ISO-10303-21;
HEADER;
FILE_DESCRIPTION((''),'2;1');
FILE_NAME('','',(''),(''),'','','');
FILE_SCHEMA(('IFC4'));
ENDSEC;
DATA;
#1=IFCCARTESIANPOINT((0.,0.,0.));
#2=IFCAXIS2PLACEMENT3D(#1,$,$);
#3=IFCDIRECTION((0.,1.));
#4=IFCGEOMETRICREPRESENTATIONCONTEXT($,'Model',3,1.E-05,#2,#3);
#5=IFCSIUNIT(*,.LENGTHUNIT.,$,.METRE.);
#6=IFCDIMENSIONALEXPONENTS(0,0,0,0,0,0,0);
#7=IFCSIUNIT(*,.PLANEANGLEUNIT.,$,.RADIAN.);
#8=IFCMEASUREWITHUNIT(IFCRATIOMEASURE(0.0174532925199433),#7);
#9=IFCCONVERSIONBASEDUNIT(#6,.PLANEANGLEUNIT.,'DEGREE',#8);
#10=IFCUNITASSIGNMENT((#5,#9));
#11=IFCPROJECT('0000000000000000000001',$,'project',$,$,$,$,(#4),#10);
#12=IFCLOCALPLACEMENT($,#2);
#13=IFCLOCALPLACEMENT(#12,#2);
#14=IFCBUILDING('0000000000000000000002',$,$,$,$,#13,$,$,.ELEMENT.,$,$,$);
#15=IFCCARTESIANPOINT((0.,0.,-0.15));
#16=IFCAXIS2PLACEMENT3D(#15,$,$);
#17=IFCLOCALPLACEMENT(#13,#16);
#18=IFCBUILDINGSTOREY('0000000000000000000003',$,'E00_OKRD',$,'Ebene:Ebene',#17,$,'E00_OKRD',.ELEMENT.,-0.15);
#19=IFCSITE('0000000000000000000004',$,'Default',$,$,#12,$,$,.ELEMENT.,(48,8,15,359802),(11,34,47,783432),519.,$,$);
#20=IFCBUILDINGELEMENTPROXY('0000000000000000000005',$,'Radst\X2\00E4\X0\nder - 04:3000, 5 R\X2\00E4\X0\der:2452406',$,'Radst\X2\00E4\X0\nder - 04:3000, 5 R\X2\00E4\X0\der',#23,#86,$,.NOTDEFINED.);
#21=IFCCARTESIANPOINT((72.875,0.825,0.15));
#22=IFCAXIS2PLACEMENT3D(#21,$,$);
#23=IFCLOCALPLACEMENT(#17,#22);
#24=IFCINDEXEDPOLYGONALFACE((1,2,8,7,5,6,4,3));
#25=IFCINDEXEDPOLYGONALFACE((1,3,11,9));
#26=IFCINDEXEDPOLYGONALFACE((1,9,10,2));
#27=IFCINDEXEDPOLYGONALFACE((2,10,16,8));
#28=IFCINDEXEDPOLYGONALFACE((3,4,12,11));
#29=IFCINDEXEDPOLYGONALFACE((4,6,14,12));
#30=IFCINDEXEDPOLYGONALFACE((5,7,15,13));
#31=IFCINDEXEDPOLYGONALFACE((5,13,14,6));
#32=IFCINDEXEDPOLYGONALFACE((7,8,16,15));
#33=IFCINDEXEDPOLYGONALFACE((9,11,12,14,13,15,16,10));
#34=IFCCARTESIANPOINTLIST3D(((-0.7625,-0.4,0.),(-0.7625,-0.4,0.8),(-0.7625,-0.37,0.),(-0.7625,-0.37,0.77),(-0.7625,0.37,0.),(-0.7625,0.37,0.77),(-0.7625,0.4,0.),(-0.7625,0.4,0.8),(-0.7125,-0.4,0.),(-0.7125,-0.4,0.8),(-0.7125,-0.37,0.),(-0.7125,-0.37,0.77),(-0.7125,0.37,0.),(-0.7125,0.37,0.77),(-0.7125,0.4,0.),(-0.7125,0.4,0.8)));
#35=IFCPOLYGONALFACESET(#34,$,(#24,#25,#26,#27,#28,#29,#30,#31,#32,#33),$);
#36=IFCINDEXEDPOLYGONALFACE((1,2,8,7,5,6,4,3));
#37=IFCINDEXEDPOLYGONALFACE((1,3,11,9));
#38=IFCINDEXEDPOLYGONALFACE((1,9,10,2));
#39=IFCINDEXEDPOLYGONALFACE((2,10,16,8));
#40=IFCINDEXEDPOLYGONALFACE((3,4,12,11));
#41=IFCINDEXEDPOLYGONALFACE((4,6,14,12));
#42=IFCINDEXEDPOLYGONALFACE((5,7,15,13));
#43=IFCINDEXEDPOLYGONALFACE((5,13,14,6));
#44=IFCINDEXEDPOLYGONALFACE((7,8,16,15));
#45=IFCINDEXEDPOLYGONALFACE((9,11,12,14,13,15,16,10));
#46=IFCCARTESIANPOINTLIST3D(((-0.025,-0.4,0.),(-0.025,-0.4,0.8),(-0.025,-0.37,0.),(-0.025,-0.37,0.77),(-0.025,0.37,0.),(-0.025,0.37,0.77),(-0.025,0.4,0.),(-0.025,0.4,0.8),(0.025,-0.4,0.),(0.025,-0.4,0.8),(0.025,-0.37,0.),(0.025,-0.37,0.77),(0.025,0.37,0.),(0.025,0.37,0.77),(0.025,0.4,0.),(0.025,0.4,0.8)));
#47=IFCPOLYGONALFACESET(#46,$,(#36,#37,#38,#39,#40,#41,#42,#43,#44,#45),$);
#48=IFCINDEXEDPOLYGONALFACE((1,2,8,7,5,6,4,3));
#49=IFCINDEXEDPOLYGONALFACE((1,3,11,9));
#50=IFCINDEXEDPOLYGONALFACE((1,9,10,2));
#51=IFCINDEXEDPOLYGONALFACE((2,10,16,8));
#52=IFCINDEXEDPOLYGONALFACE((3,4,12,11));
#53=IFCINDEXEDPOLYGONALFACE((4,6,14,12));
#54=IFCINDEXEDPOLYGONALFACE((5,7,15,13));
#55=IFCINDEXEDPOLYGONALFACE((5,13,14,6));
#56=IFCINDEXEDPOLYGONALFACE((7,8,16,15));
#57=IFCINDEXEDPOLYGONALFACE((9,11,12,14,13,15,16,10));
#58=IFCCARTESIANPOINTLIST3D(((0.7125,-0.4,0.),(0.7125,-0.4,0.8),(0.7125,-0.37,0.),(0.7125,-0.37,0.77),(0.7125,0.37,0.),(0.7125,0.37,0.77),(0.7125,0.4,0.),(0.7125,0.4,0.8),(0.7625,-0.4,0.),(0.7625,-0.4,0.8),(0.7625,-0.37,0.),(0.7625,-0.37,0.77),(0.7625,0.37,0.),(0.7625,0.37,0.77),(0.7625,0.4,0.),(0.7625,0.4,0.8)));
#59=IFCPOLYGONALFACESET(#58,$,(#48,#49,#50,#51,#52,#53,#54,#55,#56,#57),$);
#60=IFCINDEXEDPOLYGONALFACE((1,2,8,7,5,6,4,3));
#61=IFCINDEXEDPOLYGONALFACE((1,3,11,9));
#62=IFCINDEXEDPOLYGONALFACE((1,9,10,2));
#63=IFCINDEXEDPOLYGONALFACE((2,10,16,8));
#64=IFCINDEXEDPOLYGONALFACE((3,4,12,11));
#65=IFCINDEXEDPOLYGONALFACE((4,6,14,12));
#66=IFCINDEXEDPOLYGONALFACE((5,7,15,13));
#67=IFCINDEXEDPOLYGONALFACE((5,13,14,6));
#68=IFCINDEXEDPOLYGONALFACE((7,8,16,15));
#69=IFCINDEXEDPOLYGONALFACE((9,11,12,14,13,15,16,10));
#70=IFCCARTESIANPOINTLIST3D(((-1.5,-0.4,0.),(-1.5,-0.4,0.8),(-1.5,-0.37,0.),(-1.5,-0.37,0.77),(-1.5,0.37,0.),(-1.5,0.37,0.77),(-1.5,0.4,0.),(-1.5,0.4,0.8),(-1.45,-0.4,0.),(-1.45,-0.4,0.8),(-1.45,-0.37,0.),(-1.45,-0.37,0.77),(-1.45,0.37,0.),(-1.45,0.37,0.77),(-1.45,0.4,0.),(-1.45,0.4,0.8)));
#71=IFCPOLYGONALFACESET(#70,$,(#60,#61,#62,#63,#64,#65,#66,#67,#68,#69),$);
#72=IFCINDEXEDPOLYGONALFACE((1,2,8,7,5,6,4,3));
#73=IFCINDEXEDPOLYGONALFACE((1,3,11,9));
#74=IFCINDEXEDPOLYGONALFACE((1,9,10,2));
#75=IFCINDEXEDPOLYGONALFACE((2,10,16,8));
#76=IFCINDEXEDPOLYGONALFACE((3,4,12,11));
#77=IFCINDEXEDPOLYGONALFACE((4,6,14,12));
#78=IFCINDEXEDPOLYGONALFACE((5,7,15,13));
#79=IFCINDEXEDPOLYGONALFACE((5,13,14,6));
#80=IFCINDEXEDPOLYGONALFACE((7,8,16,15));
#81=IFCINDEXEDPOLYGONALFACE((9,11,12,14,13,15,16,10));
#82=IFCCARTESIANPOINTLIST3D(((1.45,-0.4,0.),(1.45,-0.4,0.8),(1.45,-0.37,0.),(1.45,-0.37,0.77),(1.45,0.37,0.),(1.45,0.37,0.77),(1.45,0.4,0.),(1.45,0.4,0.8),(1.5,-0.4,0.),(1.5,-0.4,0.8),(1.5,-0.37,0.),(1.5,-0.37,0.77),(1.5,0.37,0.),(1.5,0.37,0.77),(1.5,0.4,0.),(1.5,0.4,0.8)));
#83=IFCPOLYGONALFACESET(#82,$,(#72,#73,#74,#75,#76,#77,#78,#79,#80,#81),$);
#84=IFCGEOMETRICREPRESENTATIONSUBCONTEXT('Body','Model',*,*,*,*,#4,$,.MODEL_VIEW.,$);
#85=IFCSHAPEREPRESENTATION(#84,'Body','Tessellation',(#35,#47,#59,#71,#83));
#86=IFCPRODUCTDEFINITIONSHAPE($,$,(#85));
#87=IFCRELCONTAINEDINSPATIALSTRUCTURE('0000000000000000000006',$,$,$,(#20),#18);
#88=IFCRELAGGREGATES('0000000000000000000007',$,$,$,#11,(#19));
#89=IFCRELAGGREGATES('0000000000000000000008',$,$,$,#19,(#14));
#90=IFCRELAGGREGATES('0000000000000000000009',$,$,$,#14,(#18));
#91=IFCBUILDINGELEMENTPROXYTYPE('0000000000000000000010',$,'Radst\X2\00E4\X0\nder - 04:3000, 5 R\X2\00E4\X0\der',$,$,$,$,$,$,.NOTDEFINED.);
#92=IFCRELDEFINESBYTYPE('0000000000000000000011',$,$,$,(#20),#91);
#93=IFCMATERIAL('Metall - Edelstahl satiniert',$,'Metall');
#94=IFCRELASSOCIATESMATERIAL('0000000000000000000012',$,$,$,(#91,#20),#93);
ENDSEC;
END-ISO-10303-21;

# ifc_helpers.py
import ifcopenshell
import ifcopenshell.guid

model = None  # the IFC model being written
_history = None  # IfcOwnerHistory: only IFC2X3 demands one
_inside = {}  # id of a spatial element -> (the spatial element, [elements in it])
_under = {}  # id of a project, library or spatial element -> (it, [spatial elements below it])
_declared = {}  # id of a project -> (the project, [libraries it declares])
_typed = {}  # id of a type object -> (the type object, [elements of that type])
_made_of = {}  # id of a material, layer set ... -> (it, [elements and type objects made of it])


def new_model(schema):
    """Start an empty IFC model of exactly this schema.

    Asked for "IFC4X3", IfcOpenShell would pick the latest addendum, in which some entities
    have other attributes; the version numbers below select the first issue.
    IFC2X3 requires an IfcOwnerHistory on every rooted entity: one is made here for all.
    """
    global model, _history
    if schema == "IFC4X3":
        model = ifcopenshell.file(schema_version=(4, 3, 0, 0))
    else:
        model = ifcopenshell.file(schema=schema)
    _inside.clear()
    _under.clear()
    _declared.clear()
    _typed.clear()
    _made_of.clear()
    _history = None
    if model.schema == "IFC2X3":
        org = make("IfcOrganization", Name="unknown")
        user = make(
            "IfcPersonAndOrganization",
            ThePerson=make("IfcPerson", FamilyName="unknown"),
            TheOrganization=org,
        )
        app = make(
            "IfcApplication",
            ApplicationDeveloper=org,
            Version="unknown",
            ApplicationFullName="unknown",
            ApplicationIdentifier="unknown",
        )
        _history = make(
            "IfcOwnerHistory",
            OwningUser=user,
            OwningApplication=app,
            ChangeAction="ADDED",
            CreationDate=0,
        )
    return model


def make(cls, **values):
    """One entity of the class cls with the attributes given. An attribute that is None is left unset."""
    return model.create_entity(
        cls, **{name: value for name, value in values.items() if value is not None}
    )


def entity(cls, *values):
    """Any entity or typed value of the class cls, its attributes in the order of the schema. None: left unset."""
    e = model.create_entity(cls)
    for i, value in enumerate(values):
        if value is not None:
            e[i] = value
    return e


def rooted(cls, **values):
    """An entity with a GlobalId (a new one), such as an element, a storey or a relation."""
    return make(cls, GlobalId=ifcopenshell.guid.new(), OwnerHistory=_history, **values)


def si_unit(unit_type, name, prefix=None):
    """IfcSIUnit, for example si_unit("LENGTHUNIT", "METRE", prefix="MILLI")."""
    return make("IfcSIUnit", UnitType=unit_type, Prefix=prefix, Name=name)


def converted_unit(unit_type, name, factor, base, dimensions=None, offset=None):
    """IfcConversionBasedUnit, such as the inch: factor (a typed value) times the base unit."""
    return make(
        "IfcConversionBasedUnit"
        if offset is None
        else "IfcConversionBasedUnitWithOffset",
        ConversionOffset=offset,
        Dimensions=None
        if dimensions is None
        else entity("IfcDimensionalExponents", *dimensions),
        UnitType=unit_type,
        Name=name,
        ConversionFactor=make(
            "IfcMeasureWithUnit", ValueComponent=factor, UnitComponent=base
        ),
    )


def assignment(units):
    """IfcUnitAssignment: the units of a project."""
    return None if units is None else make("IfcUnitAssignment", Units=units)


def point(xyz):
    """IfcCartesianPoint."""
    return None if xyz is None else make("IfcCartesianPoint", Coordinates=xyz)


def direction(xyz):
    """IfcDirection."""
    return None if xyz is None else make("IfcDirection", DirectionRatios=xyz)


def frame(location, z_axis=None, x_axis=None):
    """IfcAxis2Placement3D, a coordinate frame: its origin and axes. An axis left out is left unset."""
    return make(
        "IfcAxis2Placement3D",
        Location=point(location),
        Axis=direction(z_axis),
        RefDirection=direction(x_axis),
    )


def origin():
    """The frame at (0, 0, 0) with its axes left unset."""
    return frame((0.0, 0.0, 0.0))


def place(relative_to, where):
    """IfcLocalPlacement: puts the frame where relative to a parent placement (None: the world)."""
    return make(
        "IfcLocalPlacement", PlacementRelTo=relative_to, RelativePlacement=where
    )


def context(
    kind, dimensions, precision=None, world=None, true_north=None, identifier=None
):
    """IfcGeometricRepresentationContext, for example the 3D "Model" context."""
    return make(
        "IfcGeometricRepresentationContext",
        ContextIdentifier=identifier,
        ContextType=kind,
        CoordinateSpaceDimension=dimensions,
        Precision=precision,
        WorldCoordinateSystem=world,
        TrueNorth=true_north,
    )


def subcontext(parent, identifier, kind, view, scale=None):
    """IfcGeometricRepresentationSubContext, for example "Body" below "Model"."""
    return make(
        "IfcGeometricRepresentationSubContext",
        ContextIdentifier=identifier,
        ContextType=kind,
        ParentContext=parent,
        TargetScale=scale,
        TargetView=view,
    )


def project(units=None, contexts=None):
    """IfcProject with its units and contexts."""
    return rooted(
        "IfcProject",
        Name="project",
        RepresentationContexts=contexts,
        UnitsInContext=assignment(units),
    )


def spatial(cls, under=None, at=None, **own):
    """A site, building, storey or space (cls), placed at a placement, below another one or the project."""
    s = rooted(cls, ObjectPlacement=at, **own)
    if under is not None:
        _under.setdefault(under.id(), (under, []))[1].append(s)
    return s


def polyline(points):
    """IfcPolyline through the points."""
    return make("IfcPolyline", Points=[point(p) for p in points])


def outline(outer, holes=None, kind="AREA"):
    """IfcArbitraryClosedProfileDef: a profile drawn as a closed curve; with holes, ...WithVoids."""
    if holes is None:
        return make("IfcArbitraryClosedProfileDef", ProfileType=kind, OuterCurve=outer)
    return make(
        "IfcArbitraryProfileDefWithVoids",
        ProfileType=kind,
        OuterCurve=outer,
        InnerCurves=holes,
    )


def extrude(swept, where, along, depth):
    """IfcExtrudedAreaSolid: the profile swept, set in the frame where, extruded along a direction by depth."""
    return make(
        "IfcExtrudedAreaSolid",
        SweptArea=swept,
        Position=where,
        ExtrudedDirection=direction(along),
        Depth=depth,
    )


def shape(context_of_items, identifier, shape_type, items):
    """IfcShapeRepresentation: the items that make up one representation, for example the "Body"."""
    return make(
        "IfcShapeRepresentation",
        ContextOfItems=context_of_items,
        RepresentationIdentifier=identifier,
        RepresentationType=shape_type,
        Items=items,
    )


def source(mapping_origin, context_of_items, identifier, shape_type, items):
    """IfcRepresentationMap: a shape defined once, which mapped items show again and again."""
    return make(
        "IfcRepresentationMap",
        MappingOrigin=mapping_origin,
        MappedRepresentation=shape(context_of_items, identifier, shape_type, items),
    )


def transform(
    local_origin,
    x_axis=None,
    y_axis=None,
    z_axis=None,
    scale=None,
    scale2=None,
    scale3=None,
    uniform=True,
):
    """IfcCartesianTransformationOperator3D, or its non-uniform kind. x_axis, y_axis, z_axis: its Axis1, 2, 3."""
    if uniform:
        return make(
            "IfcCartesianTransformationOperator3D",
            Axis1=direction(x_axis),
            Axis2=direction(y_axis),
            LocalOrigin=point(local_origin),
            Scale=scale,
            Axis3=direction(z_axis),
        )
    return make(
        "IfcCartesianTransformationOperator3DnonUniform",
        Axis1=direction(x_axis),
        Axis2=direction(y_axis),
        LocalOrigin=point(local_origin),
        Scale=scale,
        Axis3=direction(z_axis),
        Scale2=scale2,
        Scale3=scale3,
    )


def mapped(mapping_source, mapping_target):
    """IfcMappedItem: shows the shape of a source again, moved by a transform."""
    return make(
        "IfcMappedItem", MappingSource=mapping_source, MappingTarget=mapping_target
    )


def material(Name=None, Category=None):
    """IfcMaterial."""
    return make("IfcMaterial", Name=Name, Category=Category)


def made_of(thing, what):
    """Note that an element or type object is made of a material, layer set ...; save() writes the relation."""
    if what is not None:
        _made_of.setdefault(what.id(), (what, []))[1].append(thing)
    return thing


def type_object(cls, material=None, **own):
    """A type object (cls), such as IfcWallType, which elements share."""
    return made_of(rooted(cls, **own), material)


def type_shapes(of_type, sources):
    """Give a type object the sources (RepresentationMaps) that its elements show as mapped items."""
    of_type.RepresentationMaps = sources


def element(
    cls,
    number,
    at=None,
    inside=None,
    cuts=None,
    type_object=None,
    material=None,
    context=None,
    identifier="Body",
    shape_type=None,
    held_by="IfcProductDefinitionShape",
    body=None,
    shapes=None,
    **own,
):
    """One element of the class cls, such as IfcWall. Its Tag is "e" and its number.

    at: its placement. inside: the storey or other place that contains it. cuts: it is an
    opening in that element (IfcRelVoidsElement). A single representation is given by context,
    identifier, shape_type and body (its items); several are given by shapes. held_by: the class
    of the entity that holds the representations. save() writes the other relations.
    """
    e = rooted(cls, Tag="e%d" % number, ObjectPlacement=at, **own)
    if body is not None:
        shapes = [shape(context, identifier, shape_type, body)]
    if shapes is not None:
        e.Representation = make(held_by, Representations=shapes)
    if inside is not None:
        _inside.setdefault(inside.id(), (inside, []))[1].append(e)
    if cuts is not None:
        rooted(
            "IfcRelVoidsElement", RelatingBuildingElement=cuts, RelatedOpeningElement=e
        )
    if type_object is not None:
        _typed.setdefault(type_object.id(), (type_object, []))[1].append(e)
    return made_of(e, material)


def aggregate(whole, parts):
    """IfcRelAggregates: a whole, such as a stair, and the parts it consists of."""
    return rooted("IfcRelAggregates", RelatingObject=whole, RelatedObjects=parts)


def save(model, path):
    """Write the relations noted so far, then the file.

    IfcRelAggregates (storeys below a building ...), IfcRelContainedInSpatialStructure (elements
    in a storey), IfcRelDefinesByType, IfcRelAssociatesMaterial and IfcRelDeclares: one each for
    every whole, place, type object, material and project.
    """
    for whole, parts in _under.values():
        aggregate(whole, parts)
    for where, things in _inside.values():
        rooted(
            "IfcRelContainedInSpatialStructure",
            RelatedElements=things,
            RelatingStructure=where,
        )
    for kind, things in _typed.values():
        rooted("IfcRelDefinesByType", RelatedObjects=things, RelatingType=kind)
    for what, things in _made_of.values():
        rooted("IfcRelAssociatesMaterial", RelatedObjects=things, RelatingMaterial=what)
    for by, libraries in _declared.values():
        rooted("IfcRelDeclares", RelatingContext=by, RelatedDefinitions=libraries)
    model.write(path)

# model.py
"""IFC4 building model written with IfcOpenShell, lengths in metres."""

from ifc_helpers import new_model, entity, si_unit, converted_unit, direction, frame, origin, place, context, subcontext, project, spatial, polyline, outline, extrude, source, transform, mapped, material, type_object, type_shapes, element, save


model = new_model("IFC4")

# Units and contexts
model_context = context("Model", 3, precision=1e-05, world=origin(), true_north=direction((0.0, 1.0)))
body_context = subcontext(model_context, "Body", "Model", "MODEL_VIEW")
ifc_project = project(units=[si_unit("LENGTHUNIT", "METRE"), converted_unit("PLANEANGLEUNIT", "DEGREE", entity("IfcRatioMeasure", 0.0174532925199433), si_unit("PLANEANGLEUNIT", "RADIAN"), dimensions=[0, 0, 0, 0, 0, 0, 0])], contexts=[model_context])

# Site, building, storey
site_placement = place(None, frame((0.0, 0.0, 0.0)))
site = spatial("IfcSite", under=ifc_project, at=site_placement, Name="Default", CompositionType="ELEMENT", RefLatitude=(48, 8, 15, 359802), RefLongitude=(11, 34, 47, 783432), RefElevation=519.0)
building_placement = place(site_placement, origin())
building = spatial("IfcBuilding", under=site, at=building_placement, CompositionType="ELEMENT")
storey_placement = place(building_placement, frame((0.0, 0.0, -0.15)))
storey = spatial("IfcBuildingStorey", under=building, at=storey_placement, Name="E00_OKRD", ObjectType="Ebene:Ebene", LongName="E00_OKRD", CompositionType="ELEMENT", Elevation=-0.15)

# Building element proxy
ifc_material_1 = material(Name="Metall - Edelstahl satiniert", Category="Metall")
building_element_proxy_type_1 = type_object("IfcBuildingElementProxyType", Name="Radständer - 04:3000, 5 Räder", PredefinedType="NOTDEFINED", material=ifc_material_1)
shared_shape_1 = source(origin(), body_context, "Body", "SweptSolid", [
    extrude(outline(polyline([(-0.4075, -0.4), (0.3925, -0.4), (0.3925, -0.37), (-0.3775, -0.37), (-0.3775, 0.37), (0.3925, 0.37), (0.3925, 0.4), (-0.4075, 0.4), (-0.4075, -0.4)])), frame((-0.7625, 0.0, 0.3925), z_axis=(1.0, 0.0, 0.0), x_axis=(0.0, 0.0, -1.0)), (0.0, 0.0, 1.0), 0.05),
    extrude(outline(polyline([(-0.4075, -0.4), (0.3925, -0.4), (0.3925, -0.37), (-0.3775, -0.37), (-0.3775, 0.37), (0.3925, 0.37), (0.3925, 0.4), (-0.4075, 0.4), (-0.4075, -0.4)])), frame((-0.025, 0.0, 0.3925), z_axis=(1.0, 0.0, 0.0), x_axis=(0.0, 0.0, -1.0)), (0.0, 0.0, 1.0), 0.05),
    extrude(outline(polyline([(-0.4075, -0.4), (0.3925, -0.4), (0.3925, -0.37), (-0.3775, -0.37), (-0.3775, 0.37), (0.3925, 0.37), (0.3925, 0.4), (-0.4075, 0.4), (-0.4075, -0.4)])), frame((0.7125, 0.0, 0.3925), z_axis=(1.0, 0.0, 0.0), x_axis=(0.0, 0.0, -1.0)), (0.0, 0.0, 1.0), 0.05),
    extrude(outline(polyline([(-0.4075, -0.4), (0.3925, -0.4), (0.3925, -0.37), (-0.3775, -0.37), (-0.3775, 0.37), (0.3925, 0.37), (0.3925, 0.4), (-0.4075, 0.4), (-0.4075, -0.4)])), frame((-1.5, 0.0, 0.3925), z_axis=(1.0, 0.0, 0.0), x_axis=(0.0, 0.0, -1.0)), (0.0, 0.0, 1.0), 0.05),
    extrude(outline(polyline([(-0.4075, -0.4), (0.3925, -0.4), (0.3925, -0.37), (-0.3775, -0.37), (-0.3775, 0.37), (0.3925, 0.37), (0.3925, 0.4), (-0.4075, 0.4), (-0.4075, -0.4)])), frame((1.45, 0.0, 0.3925), z_axis=(1.0, 0.0, 0.0), x_axis=(0.0, 0.0, -1.0)), (0.0, 0.0, 1.0), 0.05),
])
type_shapes(building_element_proxy_type_1, [shared_shape_1])
proxy_1_placement = place(storey_placement, frame((72.875, 0.825, 0.15)))
element("IfcBuildingElementProxy", 1, at=proxy_1_placement, inside=storey, type_object=building_element_proxy_type_1, material=ifc_material_1, Name="Radständer - 04:3000, 5 Räder:2452406", ObjectType="Radständer - 04:3000, 5 Räder", PredefinedType="NOTDEFINED", context=body_context, shape_type="MappedRepresentation", body=[
    mapped(shared_shape_1, transform((0.0, 0.0, 0.0), scale=1.0)),
])

save(model, "model.ifc")
